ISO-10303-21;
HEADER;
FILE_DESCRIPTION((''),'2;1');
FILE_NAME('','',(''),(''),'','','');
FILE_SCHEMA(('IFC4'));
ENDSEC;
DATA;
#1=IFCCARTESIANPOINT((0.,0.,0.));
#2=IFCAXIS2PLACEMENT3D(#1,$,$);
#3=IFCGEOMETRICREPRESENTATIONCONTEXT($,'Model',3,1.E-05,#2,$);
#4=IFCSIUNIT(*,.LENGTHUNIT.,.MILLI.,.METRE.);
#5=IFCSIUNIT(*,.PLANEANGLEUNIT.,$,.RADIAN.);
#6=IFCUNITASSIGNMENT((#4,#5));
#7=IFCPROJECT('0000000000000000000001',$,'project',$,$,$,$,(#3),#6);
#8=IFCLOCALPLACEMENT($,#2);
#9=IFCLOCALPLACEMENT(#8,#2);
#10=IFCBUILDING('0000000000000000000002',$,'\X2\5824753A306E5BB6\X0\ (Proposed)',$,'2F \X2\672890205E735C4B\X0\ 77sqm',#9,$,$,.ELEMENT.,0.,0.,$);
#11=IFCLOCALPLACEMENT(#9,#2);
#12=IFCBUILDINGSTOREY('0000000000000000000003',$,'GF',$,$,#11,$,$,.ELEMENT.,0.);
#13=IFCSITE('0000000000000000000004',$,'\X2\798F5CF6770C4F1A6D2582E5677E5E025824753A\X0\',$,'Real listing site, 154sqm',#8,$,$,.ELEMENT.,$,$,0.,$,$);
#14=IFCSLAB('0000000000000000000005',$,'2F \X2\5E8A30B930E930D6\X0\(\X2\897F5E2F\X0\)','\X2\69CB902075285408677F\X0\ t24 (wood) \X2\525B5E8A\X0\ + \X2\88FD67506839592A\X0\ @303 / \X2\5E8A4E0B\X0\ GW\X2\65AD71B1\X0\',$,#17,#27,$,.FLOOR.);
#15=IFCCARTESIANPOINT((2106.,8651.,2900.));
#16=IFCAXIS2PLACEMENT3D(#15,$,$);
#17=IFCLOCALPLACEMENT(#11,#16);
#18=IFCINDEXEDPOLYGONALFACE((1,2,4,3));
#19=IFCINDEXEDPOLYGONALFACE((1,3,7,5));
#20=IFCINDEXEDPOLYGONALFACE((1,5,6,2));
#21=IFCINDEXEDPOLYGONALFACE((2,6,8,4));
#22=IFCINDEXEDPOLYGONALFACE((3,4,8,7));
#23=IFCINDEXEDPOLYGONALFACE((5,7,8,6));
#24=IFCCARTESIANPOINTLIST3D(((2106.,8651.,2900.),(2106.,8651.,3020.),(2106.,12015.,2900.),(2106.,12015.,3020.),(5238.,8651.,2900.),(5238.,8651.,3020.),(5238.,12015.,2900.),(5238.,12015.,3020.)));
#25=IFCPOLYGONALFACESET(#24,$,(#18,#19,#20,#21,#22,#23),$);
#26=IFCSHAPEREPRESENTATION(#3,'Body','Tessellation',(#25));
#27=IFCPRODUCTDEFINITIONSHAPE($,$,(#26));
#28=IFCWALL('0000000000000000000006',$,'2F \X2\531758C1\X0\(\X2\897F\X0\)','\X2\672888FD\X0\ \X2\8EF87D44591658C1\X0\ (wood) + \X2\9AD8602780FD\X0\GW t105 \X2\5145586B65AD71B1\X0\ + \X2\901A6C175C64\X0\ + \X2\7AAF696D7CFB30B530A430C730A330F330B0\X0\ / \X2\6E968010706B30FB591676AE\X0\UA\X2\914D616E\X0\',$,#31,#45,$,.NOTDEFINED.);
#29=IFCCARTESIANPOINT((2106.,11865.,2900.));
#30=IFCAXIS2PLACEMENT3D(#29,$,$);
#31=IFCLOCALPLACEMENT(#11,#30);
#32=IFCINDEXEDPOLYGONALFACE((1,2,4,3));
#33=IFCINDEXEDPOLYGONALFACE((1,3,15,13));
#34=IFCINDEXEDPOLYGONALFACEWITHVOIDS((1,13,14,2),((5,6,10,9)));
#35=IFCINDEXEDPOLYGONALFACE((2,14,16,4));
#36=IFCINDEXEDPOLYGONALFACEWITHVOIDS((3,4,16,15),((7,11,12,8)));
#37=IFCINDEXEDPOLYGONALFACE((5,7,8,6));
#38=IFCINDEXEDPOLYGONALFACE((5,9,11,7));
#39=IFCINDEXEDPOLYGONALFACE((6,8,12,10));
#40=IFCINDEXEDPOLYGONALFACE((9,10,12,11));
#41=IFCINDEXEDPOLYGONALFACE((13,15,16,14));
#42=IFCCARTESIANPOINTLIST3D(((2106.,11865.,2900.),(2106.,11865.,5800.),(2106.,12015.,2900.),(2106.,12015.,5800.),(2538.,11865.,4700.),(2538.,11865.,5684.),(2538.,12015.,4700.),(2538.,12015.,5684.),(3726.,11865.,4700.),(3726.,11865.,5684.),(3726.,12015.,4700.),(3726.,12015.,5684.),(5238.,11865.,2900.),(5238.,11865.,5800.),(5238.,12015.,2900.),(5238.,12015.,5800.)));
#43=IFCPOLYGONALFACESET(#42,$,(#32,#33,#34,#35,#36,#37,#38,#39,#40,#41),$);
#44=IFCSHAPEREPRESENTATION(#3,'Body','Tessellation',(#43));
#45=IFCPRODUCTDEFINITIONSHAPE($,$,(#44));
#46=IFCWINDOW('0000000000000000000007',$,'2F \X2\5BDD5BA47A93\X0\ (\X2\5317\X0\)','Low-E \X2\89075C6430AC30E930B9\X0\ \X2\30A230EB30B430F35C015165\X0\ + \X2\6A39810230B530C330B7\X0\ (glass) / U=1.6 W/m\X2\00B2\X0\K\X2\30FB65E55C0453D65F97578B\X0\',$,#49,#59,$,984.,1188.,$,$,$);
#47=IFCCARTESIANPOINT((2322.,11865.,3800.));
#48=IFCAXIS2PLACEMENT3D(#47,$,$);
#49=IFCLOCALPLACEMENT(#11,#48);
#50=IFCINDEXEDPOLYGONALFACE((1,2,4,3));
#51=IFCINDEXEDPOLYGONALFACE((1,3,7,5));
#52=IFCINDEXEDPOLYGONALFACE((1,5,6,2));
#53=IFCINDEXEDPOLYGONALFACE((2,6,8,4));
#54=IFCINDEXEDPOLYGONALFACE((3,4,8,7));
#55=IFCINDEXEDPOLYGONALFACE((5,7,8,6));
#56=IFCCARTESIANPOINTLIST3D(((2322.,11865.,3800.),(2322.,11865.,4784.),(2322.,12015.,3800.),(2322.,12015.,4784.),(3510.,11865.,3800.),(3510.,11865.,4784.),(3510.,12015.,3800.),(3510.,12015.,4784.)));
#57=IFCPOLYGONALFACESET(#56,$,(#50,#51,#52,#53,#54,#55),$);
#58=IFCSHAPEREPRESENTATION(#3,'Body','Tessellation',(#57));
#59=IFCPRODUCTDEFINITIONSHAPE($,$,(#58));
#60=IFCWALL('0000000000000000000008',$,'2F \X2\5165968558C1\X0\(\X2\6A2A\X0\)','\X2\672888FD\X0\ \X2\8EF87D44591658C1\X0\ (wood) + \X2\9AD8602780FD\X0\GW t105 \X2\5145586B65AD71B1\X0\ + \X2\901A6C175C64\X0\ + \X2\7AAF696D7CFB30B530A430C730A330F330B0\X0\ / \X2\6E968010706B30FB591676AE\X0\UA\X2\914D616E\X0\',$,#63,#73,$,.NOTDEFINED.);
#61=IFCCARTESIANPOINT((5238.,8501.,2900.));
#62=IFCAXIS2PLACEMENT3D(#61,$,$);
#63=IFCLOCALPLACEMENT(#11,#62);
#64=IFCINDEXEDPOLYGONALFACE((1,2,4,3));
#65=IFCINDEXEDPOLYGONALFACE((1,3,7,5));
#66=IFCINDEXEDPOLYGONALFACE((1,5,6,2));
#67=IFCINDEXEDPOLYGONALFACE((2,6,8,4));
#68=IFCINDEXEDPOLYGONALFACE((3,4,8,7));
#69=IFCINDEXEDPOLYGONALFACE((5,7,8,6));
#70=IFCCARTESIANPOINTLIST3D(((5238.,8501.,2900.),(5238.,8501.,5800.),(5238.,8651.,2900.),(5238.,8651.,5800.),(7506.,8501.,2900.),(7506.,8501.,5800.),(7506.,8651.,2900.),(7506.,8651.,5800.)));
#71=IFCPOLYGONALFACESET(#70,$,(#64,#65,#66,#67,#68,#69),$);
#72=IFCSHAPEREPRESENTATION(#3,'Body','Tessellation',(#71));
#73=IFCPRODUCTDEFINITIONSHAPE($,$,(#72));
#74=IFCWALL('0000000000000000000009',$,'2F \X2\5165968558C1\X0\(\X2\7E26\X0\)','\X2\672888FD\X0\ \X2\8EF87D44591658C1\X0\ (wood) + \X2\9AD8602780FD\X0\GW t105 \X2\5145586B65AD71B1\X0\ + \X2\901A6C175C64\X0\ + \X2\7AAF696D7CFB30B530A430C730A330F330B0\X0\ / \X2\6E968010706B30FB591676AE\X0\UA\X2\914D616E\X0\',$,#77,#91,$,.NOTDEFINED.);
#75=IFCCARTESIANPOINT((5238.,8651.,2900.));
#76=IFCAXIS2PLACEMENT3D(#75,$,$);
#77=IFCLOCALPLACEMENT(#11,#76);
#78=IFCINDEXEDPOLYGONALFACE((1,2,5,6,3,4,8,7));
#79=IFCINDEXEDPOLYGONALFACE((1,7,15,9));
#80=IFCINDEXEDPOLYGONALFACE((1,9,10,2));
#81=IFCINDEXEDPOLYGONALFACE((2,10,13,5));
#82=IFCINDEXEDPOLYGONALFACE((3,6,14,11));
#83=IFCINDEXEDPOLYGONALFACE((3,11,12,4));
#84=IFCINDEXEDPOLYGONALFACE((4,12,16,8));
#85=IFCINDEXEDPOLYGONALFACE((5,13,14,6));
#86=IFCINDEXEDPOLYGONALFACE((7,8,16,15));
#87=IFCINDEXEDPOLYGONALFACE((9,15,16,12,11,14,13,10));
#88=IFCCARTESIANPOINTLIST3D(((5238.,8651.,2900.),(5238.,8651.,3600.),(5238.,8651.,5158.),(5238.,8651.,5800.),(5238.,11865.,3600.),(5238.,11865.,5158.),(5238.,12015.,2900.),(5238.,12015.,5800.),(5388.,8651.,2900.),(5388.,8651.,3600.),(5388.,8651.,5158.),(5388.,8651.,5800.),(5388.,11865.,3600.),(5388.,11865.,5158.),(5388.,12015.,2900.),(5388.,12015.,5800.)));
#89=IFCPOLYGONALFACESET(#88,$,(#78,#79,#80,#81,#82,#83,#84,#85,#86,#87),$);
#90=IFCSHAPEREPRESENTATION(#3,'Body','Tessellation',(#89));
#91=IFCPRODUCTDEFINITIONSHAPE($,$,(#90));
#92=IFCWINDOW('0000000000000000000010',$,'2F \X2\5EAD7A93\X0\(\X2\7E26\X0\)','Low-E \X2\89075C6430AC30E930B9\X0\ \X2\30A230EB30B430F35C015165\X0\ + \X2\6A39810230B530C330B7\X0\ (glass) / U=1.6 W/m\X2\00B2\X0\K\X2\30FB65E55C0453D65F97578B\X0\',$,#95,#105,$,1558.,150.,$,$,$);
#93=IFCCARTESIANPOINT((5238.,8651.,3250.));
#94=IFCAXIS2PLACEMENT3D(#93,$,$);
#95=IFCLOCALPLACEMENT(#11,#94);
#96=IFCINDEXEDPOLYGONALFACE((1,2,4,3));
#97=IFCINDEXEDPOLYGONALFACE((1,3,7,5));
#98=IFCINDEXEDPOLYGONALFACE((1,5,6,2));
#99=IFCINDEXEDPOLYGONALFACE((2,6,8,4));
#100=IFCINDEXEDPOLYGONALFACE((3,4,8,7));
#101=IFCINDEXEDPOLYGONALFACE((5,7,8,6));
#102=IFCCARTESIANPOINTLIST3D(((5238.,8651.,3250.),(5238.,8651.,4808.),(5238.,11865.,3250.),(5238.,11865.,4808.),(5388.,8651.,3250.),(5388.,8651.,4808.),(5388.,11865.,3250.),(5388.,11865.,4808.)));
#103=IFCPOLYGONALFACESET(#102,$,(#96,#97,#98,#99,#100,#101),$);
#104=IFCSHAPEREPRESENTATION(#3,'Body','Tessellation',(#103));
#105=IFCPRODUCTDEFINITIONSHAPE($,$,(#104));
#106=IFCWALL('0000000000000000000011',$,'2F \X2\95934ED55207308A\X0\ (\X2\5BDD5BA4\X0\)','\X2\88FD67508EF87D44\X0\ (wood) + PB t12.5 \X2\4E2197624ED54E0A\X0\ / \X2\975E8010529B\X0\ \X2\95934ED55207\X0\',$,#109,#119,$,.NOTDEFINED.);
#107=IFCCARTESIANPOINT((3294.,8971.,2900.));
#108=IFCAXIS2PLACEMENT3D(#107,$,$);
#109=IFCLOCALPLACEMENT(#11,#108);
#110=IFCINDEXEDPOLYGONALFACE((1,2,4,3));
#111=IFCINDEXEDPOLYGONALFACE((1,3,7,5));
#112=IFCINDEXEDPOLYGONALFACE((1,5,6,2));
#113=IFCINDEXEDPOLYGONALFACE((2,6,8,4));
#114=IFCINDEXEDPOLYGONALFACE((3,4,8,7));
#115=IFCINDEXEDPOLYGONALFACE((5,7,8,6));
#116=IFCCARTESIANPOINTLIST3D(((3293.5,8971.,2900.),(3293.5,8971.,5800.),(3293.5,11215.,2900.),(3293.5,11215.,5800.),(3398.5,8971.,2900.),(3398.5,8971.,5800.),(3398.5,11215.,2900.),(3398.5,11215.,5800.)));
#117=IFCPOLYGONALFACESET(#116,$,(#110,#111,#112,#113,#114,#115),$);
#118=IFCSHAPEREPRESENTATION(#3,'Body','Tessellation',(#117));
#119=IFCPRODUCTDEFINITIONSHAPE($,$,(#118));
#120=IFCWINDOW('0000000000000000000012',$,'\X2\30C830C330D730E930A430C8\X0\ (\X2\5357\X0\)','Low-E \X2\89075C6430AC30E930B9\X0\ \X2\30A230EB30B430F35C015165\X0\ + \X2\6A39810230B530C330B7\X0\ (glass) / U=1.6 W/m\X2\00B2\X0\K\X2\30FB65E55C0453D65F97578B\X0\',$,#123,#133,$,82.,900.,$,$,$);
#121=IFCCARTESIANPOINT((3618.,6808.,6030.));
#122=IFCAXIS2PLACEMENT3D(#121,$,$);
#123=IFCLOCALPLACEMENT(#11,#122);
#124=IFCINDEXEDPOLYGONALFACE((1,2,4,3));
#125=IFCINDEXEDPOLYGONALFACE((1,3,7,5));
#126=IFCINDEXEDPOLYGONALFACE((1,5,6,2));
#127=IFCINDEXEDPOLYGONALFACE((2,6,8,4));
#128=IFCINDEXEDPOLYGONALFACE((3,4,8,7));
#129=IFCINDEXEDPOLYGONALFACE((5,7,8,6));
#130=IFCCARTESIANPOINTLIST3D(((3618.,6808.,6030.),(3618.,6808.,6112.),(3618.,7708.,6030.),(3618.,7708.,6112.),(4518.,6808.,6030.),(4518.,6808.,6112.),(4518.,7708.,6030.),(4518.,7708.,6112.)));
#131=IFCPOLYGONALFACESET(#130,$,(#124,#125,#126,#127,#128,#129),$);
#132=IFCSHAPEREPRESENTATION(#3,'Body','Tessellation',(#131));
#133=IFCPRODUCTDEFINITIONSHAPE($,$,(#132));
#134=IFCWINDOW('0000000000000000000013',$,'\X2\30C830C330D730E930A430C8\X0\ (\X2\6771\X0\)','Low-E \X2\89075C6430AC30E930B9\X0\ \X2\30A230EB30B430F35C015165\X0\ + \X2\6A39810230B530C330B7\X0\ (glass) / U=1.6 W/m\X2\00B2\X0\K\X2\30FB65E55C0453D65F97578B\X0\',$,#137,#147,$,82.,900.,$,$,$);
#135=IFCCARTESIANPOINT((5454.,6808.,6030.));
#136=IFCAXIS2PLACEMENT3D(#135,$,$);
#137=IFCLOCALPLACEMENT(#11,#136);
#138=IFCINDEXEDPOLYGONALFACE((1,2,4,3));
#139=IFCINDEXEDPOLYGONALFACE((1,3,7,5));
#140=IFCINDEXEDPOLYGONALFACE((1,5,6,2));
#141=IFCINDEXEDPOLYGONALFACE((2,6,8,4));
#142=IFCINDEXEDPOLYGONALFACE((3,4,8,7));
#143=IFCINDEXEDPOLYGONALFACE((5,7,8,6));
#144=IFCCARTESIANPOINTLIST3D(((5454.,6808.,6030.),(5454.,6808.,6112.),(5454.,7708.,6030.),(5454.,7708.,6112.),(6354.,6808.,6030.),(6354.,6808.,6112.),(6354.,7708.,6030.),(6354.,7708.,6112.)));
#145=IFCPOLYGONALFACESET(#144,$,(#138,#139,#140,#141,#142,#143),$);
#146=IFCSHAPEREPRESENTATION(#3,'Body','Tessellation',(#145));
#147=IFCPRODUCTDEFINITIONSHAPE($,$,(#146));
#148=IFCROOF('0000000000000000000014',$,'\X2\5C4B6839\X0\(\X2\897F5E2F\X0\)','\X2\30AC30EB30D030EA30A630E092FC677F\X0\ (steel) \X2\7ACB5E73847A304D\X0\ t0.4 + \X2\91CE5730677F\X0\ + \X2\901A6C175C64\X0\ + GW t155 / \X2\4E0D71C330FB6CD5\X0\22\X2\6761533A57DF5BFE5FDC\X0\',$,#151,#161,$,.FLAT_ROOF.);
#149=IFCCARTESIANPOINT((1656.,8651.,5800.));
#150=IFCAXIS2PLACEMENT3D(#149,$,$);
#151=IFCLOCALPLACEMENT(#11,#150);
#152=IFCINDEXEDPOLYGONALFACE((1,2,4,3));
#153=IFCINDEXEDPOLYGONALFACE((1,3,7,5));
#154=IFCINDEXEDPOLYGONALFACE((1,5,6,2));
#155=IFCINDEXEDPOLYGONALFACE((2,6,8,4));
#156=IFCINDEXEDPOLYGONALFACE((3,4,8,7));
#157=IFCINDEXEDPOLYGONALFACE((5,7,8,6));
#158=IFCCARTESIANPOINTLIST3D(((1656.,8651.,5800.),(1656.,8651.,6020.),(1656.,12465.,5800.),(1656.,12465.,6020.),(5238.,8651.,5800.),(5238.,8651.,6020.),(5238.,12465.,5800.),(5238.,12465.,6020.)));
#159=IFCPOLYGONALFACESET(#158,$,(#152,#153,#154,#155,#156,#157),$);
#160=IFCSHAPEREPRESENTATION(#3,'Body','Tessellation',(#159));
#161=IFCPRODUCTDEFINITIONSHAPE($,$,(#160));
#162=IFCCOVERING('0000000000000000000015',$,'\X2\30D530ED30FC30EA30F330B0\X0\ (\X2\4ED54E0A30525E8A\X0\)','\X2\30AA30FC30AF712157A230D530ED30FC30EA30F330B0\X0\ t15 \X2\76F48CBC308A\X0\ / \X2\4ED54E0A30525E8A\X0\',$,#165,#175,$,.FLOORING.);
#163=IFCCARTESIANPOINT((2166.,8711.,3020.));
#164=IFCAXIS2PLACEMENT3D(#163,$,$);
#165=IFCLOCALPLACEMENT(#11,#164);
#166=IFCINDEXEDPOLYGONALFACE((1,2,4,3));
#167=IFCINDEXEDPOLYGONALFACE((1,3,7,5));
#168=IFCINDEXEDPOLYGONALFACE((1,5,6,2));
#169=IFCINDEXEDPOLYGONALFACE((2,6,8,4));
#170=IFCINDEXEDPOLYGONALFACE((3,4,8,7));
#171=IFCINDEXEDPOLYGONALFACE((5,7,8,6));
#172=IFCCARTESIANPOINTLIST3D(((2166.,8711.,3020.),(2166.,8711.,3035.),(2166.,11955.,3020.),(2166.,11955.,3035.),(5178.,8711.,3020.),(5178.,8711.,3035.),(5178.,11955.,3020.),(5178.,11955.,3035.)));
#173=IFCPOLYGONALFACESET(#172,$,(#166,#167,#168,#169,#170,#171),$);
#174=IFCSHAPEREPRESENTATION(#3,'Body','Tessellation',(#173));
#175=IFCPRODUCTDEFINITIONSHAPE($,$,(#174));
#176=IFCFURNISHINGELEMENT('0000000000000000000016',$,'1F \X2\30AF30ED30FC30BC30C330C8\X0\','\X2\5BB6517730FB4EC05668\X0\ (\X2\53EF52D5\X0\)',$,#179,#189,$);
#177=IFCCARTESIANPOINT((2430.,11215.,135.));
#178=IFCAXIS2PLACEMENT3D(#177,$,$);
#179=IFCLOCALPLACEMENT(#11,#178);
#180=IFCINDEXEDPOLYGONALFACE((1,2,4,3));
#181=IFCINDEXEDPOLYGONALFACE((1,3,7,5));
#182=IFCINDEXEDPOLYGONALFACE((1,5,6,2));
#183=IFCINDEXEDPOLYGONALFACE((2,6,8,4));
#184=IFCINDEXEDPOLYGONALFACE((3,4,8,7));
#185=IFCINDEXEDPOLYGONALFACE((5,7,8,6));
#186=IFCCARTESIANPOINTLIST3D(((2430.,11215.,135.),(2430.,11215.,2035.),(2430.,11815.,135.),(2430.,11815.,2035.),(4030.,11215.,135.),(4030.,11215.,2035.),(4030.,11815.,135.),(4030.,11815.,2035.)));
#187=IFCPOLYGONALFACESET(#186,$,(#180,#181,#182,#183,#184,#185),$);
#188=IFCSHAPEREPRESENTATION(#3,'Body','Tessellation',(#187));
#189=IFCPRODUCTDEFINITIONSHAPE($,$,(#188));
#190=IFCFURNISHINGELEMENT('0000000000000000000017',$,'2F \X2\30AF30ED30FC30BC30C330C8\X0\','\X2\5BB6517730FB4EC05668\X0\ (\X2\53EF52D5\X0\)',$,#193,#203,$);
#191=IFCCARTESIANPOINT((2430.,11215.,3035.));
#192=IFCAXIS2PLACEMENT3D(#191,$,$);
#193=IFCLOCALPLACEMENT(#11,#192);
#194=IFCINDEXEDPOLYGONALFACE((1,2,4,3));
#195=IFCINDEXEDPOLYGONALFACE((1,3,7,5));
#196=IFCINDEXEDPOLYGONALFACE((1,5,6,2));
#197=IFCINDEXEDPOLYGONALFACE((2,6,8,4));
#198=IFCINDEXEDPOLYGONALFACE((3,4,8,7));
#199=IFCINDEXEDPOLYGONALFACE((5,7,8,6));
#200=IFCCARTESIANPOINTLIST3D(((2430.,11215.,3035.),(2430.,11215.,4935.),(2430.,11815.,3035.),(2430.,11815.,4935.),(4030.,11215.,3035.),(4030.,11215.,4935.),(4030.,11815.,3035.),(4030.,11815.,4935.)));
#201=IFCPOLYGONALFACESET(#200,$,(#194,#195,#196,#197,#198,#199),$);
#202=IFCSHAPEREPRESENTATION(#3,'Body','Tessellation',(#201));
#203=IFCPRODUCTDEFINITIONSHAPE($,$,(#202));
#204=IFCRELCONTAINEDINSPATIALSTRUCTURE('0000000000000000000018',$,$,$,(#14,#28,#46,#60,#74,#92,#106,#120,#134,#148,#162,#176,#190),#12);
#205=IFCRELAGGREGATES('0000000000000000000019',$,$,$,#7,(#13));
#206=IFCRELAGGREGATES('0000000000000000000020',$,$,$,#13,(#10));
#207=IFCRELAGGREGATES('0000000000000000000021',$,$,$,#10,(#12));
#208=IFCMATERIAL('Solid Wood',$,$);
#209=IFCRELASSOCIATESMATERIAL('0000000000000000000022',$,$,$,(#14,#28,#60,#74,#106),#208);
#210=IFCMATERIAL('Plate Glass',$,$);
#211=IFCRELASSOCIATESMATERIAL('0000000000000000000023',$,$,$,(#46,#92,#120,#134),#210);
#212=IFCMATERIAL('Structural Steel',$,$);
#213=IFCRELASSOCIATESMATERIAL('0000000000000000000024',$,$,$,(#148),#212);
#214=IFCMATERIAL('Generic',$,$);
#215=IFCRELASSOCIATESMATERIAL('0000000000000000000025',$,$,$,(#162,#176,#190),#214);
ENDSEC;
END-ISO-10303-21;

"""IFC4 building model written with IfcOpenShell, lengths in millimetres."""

from ifc_helpers import new_model, si_unit, frame, frame_2d, origin, place, context, project, spatial, rectangle, extrude, material, element, fill, save


model = new_model("IFC4")

# Units and contexts
model_context = context("Model", 3, precision=1e-05, world=origin())
ifc_project = project(units=[si_unit("LENGTHUNIT", "METRE", prefix="MILLI"), si_unit("PLANEANGLEUNIT", "RADIAN")], contexts=[model_context])

# Site, building, storey
site_placement = place(None, origin())
site = spatial("IfcSite", under=ifc_project, at=site_placement, Name="福島県会津若松市堤町", ObjectType="Real listing site, 154sqm", CompositionType="ELEMENT", RefElevation=0.0)
building_placement = place(site_placement, origin())
building = spatial("IfcBuilding", under=site, at=building_placement, Name="堤町の家 (Proposed)", ObjectType="2F 木造平屋 77sqm", CompositionType="ELEMENT", ElevationOfRefHeight=0.0, ElevationOfTerrain=0.0)
storey_placement = place(building_placement, origin())
storey = spatial("IfcBuildingStorey", under=building, at=storey_placement, Name="GF", CompositionType="ELEMENT", Elevation=0.0)

# Slab
ifc_material_1 = material(Name="Solid Wood")
slab_placement = place(storey_placement, frame((2106.0, 8651.0, 2900.0)))
element("IfcSlab", 1, at=slab_placement, inside=storey, material=ifc_material_1, Name="2F 床スラブ(西帯)", Description="構造用合板 t24 (wood) 剛床 + 製材根太 @303 / 床下 GW断熱", PredefinedType="FLOOR", context=model_context, shape_type="SweptSolid", body=[
    extrude(rectangle(XDim=3132.0, YDim=3364.0, at=frame_2d((1566.0, 1682.0))), frame((2106.0, 8651.0, 2900.0)), (0.0, 0.0, 1.0), 120.0),
])

# Wall, opening, window
wall_1_placement = place(storey_placement, frame((2106.0, 11865.0, 2900.0)))
wall_1 = element("IfcWall", 2, at=wall_1_placement, inside=storey, material=ifc_material_1, Name="2F 北壁(西)", Description="木製 軸組外壁 (wood) + 高性能GW t105 充填断熱 + 通気層 + 窯業系サイディング / 準耐火・外皮UA配慮", PredefinedType="NOTDEFINED", context=model_context, shape_type="SweptSolid", body=[
    extrude(rectangle(XDim=3132.0, YDim=150.0, at=frame_2d((1566.0, 75.0))), frame((2106.0, 11865.0, 2900.0)), (0.0, 0.0, 1.0), 2900.0),
])
opening_1_placement = place(storey_placement, frame((2322.0, 11865.0, 3800.0)))
opening_1 = element("IfcOpeningElement", 3, at=opening_1_placement, cuts=wall_1, PredefinedType="NOTDEFINED", context=model_context, shape_type="SweptSolid", body=[
    extrude(rectangle(XDim=1188.0, YDim=150.0, at=frame_2d((594.0, 75.0))), frame((2322.0, 11865.0, 3800.0)), (0.0, 0.0, 1.0), 984.0),
])
ifc_material_2 = material(Name="Plate Glass")
window_1_placement = place(storey_placement, frame((2322.0, 11865.0, 3800.0)))
window_1 = element("IfcWindow", 4, at=window_1_placement, inside=storey, material=ifc_material_2, Name="2F 寝室窓 (北)", Description="Low-E 複層ガラス アルゴン封入 + 樹脂サッシ (glass) / U=1.6 W/m²K・日射取得型", OverallHeight=984.0, OverallWidth=1188.0, context=model_context, shape_type="SweptSolid", body=[
    extrude(rectangle(XDim=1188.0, YDim=150.0, at=frame_2d((594.0, 75.0))), frame((2322.0, 11865.0, 3800.0)), (0.0, 0.0, 1.0), 984.0),
])
fill(opening_1, window_1)

# Wall
wall_2_placement = place(storey_placement, frame((5238.0, 8501.0, 2900.0)))
element("IfcWall", 5, at=wall_2_placement, inside=storey, material=ifc_material_1, Name="2F 入隅壁(横)", Description="木製 軸組外壁 (wood) + 高性能GW t105 充填断熱 + 通気層 + 窯業系サイディング / 準耐火・外皮UA配慮", PredefinedType="NOTDEFINED", context=model_context, shape_type="SweptSolid", body=[
    extrude(rectangle(XDim=2268.0, YDim=150.0, at=frame_2d((1134.0, 75.0))), frame((5238.0, 8501.0, 2900.0)), (0.0, 0.0, 1.0), 2900.0),
])

# Wall, opening, window
wall_3_placement = place(storey_placement, frame((5238.0, 8651.0, 2900.0)))
wall_3 = element("IfcWall", 6, at=wall_3_placement, inside=storey, material=ifc_material_1, Name="2F 入隅壁(縦)", Description="木製 軸組外壁 (wood) + 高性能GW t105 充填断熱 + 通気層 + 窯業系サイディング / 準耐火・外皮UA配慮", PredefinedType="NOTDEFINED", context=model_context, shape_type="SweptSolid", body=[
    extrude(rectangle(XDim=150.0, YDim=3364.0, at=frame_2d((75.0, 1682.0))), frame((5238.0, 8651.0, 2900.0)), (0.0, 0.0, 1.0), 2900.0),
])
opening_2_placement = place(storey_placement, frame((5238.0, 8651.0, 3250.0)))
opening_2 = element("IfcOpeningElement", 7, at=opening_2_placement, cuts=wall_3, PredefinedType="NOTDEFINED", context=model_context, shape_type="SweptSolid", body=[
    extrude(rectangle(XDim=150.0, YDim=3214.0, at=frame_2d((75.0, 1607.0))), frame((5238.0, 8651.0, 3250.0)), (0.0, 0.0, 1.0), 1558.0),
])
window_2_placement = place(storey_placement, frame((5238.0, 8651.0, 3250.0)))
window_2 = element("IfcWindow", 8, at=window_2_placement, inside=storey, material=ifc_material_2, Name="2F 庭窓(縦)", Description="Low-E 複層ガラス アルゴン封入 + 樹脂サッシ (glass) / U=1.6 W/m²K・日射取得型", OverallHeight=1558.0, OverallWidth=150.0, context=model_context, shape_type="SweptSolid", body=[
    extrude(rectangle(XDim=150.0, YDim=3214.0, at=frame_2d((75.0, 1607.0))), frame((5238.0, 8651.0, 3250.0)), (0.0, 0.0, 1.0), 1558.0),
])
fill(opening_2, window_2)

# Wall
wall_4_placement = place(storey_placement, frame((3294.0, 8971.0, 2900.0)))
element("IfcWall", 9, at=wall_4_placement, inside=storey, material=ifc_material_1, Name="2F 間仕切り (寝室)", Description="製材軸組 (wood) + PB t12.5 両面仕上 / 非耐力 間仕切", PredefinedType="NOTDEFINED", context=model_context, shape_type="SweptSolid", body=[
    extrude(rectangle(XDim=105.0, YDim=2244.0, at=frame_2d((52.0, 1122.0))), frame((3294.0, 8971.0, 2900.0)), (0.0, 0.0, 1.0), 2900.0),
])

# Windows
window_3_placement = place(storey_placement, frame((3618.0, 6808.0, 6030.0)))
element("IfcWindow", 10, at=window_3_placement, inside=storey, material=ifc_material_2, Name="トップライト (南)", Description="Low-E 複層ガラス アルゴン封入 + 樹脂サッシ (glass) / U=1.6 W/m²K・日射取得型", OverallHeight=82.0, OverallWidth=900.0, context=model_context, shape_type="SweptSolid", body=[
    extrude(rectangle(XDim=900.0, YDim=900.0, at=frame_2d((450.0, 450.0))), frame((3618.0, 6808.0, 6030.0)), (0.0, 0.0, 1.0), 82.0),
])
window_4_placement = place(storey_placement, frame((5454.0, 6808.0, 6030.0)))
element("IfcWindow", 11, at=window_4_placement, inside=storey, material=ifc_material_2, Name="トップライト (東)", Description="Low-E 複層ガラス アルゴン封入 + 樹脂サッシ (glass) / U=1.6 W/m²K・日射取得型", OverallHeight=82.0, OverallWidth=900.0, context=model_context, shape_type="SweptSolid", body=[
    extrude(rectangle(XDim=900.0, YDim=900.0, at=frame_2d((450.0, 450.0))), frame((5454.0, 6808.0, 6030.0)), (0.0, 0.0, 1.0), 82.0),
])

# Roof
ifc_material_3 = material(Name="Structural Steel")
for number, where, name in (
    (12, (1656.0, 8651.0, 5800.0), "屋根(西帯)"),
):
    element("IfcRoof", number, at=place(storey_placement, frame(where)), inside=storey, material=ifc_material_3, Name=name, Description="ガルバリウム鋼板 (steel) 立平葺き t0.4 + 野地板 + 通気層 + GW t155 / 不燃・法22条区域対応", PredefinedType="FLAT_ROOF", context=model_context, shape_type="SweptSolid", body=[
        extrude(rectangle(XDim=3582.0, YDim=3814.0, at=frame_2d((1791.0, 1907.0))), frame((1656.0, 8651.0, 5800.0)), (0.0, 0.0, 1.0), 220.0),
    ])

# Covering
ifc_material_4 = material(Name="Generic")
covering_placement = place(storey_placement, frame((2166.0, 8711.0, 3020.0)))
element("IfcCovering", 13, at=covering_placement, inside=storey, material=ifc_material_4, Name="フローリング (仕上げ床)", Description="オーク無垢フローリング t15 直貼り / 仕上げ床", PredefinedType="FLOORING", context=model_context, shape_type="SweptSolid", body=[
    extrude(rectangle(XDim=3012.0, YDim=3244.0, at=frame_2d((1506.0, 1622.0))), frame((2166.0, 8711.0, 3020.0)), (0.0, 0.0, 1.0), 15.0),
])

# Furnishing elements
furnishing_1_placement = place(storey_placement, frame((2430.0, 11215.0, 135.0)))
element("IfcFurnishingElement", 14, at=furnishing_1_placement, inside=storey, material=ifc_material_4, Name="1F クローゼット", Description="家具・什器 (可動)", context=model_context, shape_type="SweptSolid", body=[
    extrude(rectangle(XDim=1600.0, YDim=600.0, at=frame_2d((800.0, 300.0))), frame((2430.0, 11215.0, 135.0)), (0.0, 0.0, 1.0), 1900.0),
])
furnishing_2_placement = place(storey_placement, frame((2430.0, 11215.0, 3035.0)))
element("IfcFurnishingElement", 15, at=furnishing_2_placement, inside=storey, material=ifc_material_4, Name="2F クローゼット", Description="家具・什器 (可動)", context=model_context, shape_type="SweptSolid", body=[
    extrude(rectangle(XDim=1600.0, YDim=600.0, at=frame_2d((800.0, 300.0))), frame((2430.0, 11215.0, 3035.0)), (0.0, 0.0, 1.0), 1900.0),
])

save(model, "model.ifc")
